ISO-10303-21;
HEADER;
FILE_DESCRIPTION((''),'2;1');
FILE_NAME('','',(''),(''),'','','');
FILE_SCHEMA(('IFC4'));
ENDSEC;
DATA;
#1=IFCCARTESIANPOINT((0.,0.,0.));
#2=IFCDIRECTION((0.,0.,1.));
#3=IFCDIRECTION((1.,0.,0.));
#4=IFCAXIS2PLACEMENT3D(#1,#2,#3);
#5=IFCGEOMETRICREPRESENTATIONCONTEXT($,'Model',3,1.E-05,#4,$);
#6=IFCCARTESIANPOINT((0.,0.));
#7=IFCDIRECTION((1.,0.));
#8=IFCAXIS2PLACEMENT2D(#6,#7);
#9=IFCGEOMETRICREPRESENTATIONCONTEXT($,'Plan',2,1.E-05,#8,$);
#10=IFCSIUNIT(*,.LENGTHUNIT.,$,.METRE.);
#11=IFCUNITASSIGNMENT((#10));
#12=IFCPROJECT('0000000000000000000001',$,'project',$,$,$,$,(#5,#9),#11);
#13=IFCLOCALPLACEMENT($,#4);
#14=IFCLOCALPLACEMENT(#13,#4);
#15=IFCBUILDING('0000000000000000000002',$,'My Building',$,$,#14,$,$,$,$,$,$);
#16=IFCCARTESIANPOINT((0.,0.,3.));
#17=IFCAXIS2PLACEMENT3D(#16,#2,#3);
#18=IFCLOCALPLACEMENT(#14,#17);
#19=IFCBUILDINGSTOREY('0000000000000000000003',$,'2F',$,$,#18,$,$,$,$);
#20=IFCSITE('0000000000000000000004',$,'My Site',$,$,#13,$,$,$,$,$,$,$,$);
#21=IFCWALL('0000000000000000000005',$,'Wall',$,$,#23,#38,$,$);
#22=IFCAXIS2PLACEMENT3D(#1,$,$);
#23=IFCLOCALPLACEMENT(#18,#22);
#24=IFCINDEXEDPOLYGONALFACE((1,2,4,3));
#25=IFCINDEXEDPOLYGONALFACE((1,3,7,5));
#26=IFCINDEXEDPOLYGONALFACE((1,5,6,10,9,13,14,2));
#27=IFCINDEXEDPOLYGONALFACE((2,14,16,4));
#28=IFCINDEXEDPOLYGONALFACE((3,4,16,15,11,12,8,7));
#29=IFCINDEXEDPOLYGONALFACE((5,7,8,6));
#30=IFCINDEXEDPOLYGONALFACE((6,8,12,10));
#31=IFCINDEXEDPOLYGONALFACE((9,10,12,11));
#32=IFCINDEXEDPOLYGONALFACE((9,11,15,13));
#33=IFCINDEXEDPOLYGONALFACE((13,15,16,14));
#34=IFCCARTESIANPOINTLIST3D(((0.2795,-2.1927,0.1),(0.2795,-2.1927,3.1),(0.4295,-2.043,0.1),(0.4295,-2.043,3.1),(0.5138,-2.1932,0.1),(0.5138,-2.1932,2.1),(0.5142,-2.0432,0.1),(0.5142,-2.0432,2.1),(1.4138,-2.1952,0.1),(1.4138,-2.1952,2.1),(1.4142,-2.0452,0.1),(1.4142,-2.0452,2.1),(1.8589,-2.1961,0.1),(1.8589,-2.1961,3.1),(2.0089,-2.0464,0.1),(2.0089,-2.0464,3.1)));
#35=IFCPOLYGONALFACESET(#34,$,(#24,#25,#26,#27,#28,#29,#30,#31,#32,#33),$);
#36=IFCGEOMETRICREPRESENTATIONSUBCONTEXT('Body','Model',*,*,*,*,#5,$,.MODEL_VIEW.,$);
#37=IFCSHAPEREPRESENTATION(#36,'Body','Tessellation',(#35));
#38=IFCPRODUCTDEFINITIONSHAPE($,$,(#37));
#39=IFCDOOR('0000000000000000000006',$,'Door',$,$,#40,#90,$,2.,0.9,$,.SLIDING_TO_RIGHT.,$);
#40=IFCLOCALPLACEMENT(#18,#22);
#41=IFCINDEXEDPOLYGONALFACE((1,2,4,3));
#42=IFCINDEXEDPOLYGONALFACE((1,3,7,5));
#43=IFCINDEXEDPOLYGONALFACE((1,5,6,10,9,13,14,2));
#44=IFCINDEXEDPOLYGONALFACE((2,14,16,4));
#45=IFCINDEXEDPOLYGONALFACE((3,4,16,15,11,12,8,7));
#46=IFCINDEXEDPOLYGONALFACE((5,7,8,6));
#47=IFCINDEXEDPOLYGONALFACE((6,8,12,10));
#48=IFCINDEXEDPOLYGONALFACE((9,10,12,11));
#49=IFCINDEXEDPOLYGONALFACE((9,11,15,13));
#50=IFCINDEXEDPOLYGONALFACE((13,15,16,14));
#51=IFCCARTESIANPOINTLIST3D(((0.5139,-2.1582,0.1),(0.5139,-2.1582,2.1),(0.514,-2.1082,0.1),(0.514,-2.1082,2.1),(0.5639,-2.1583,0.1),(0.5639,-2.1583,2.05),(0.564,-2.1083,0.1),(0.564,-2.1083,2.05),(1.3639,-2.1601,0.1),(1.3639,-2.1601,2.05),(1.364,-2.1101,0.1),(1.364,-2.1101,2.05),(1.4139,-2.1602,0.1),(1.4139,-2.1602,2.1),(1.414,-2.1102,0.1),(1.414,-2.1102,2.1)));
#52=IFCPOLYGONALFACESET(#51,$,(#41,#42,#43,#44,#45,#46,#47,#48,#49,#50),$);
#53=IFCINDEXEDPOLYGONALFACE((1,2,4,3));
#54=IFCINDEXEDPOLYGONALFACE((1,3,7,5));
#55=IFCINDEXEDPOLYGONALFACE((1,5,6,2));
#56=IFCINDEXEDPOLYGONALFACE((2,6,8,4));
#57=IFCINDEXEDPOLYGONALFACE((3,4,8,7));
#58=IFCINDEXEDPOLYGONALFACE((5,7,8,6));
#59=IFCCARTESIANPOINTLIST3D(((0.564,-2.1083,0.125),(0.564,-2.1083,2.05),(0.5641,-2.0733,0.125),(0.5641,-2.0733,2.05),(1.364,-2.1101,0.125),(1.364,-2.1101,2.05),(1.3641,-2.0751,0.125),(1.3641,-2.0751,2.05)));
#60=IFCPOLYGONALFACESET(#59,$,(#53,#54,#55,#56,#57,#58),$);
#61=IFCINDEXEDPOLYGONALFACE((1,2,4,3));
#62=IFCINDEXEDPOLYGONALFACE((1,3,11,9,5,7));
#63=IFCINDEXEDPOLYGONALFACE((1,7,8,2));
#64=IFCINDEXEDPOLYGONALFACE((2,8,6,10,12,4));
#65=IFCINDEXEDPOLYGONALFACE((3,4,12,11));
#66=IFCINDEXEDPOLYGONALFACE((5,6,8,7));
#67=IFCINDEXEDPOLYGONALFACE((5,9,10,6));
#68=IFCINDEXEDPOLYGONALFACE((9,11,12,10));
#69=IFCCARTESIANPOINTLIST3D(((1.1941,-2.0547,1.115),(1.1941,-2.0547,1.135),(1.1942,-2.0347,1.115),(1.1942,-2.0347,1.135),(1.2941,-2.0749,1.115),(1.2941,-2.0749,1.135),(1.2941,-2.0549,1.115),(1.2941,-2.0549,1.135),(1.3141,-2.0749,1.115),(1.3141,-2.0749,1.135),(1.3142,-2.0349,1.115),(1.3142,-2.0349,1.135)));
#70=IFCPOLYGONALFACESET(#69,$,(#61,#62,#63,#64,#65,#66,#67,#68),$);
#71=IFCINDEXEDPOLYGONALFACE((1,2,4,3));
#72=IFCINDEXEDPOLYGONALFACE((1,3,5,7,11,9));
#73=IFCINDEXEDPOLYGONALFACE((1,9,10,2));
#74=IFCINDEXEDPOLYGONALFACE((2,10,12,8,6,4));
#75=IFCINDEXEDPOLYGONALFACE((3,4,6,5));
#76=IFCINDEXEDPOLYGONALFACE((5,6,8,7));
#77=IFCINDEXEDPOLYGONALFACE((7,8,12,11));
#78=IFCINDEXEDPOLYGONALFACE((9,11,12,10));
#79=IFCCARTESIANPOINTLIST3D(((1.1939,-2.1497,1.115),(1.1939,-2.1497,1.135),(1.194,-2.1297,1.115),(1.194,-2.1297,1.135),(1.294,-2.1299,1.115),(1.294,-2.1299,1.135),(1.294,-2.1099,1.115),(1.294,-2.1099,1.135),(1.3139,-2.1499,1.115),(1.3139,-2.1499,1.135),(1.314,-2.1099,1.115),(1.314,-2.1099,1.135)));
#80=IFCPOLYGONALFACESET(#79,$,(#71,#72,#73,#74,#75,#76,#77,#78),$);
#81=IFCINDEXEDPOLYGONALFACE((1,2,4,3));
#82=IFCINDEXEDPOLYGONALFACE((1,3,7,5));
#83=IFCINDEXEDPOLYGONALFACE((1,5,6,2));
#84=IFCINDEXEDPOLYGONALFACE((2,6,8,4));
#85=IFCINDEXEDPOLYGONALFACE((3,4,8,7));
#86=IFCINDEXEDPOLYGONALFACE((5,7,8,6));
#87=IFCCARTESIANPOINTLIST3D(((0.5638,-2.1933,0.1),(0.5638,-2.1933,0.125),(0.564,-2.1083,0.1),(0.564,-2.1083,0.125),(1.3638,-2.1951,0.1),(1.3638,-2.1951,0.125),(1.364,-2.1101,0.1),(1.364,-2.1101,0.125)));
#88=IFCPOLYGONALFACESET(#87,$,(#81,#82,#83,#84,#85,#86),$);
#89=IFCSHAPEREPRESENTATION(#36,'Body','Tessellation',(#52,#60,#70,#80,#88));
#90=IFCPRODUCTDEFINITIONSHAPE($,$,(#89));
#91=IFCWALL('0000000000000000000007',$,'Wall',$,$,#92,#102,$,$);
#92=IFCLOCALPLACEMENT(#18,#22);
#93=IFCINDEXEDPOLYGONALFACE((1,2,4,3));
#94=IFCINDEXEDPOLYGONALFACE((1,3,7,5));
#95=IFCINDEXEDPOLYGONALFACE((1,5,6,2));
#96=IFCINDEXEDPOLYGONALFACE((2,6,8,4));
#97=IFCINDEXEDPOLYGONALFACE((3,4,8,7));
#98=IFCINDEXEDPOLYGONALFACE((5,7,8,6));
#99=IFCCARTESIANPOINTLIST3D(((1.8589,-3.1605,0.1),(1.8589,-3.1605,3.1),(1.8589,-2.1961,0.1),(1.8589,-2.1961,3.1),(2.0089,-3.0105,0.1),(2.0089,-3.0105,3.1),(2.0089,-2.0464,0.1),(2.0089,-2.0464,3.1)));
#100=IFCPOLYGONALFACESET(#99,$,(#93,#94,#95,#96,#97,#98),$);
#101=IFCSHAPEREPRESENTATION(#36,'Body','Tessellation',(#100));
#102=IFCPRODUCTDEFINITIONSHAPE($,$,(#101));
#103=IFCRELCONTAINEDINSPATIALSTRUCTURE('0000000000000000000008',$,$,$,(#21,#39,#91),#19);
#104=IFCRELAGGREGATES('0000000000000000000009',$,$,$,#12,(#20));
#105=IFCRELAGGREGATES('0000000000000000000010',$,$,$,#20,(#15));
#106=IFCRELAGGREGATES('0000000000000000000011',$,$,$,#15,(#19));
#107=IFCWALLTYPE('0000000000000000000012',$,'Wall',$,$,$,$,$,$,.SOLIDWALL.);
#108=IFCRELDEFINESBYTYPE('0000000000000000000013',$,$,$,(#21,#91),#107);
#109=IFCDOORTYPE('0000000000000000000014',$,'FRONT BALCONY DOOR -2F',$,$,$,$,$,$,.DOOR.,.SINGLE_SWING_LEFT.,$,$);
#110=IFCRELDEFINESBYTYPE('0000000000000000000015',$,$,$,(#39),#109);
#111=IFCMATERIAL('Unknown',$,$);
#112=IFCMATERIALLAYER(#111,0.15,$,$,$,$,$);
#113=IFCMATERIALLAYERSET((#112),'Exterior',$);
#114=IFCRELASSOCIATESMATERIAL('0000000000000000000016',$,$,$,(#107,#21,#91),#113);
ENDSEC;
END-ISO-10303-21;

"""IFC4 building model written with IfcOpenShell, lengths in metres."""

from ifc_helpers import new_model, entity, si_unit, frame, origin_with_axes, origin_2d_with_axis, place, context, subcontext, project, spatial, line, indexed_curve, outline, extrude, shape, source, transform, mapped, material, layer, layer_set, layer_usage, type_object, type_shapes, element, fill, save


model = new_model("IFC4")

# Units and contexts
model_context = context("Model", 3, precision=1e-05, world=origin_with_axes())
plan_context = context("Plan", 2, precision=1e-05, world=origin_2d_with_axis())
body_context_1 = subcontext(model_context, "Body", "Model", "MODEL_VIEW")
body_context_2 = subcontext(plan_context, "Body", "Plan", "PLAN_VIEW")
ifc_project = project(units=[si_unit("LENGTHUNIT", "METRE")], contexts=[model_context, plan_context])

# Site, building, storey
site_placement = place(None, origin_with_axes())
site = spatial("IfcSite", under=ifc_project, at=site_placement, Name="My Site")
building_placement = place(site_placement, origin_with_axes())
building = spatial("IfcBuilding", under=site, at=building_placement, Name="My Building")
storey_placement = place(building_placement, frame((0.0, 0.0, 3.0), z_axis=(0.0, 0.0, 1.0), x_axis=(1.0, 0.0, 0.0)))
storey = spatial("IfcBuildingStorey", under=building, at=storey_placement, Name="2F")

# Shared definitions
ifc_material = material(Name="Unknown")

# Shared definitions
ifc_layer_1 = layer(ifc_material, 0.15)
ifc_layer_set_1 = layer_set([ifc_layer_1], Name="Exterior")
wall_type_1 = type_object("IfcWallType", Name="Wall", PredefinedType="SOLIDWALL", material=ifc_layer_set_1)

# Wall, opening, door
ifc_layer_usage_1 = layer_usage(ifc_layer_set_1, "AXIS2", "POSITIVE", 0.0)
wall_1_placement = place(storey_placement, frame((0.2795, -2.1927, 0.1), z_axis=(0.0, 0.0, 1.0), x_axis=(0.999998, -0.002147, 0.0)))
wall_1 = element("IfcWall", 1, at=wall_1_placement, inside=storey, type_object=wall_type_1, material=ifc_layer_usage_1, Name="Wall", context=body_context_1, shape_type="SweptSolid", body=[
    extrude(outline(indexed_curve([(0.0, 0.0), (0.1497, 0.15), (1.729, 0.15), (1.5793, 0.0)], segments=[line(1, 2, 3, 4, 1)])), origin_with_axes(), (0.0, 0.0, 1.0), 3.0),
])
shared_shape_1 = source(origin_with_axes(), body_context_1, "Body", "SweptSolid", [
    extrude(outline(indexed_curve([(0.0, 0.0), (0.9, 0.0), (0.9, 2.0), (0.0, 2.0)], segments=[line(1, 2, 3, 4, 1)])), frame((0.0, -0.6, 0.0), z_axis=(0.0, -1.0, 0.0), x_axis=(1.0, 0.0, 0.0)), (0.0, 0.0, -1.0), 1.2),
])
opening_1_placement = place(wall_1_placement, frame((1.1343, 0.085, 0.0), z_axis=(0.0, 0.0, 1.0), x_axis=(-1.0, 0.0, 0.0)))
opening_1 = element("IfcOpeningElement", 2, at=opening_1_placement, cuts=wall_1, PredefinedType="OPENING", context=body_context_1, shape_type="MappedRepresentation", body=[
    mapped(shared_shape_1, transform((0.0, 0.0, 0.0), x_axis=(1.0, 0.0, 0.0), y_axis=(0.0, 1.0, 0.0), z_axis=(0.0, 0.0, 1.0), scale=1.0)),
])
door_type_1 = type_object("IfcDoorType", Name="FRONT BALCONY DOOR -2F", OperationType="SINGLE_SWING_LEFT", PredefinedType="DOOR")
shared_shape_2 = source(origin_with_axes(), body_context_1, "Body", "SweptSolid", [
    extrude(outline(indexed_curve([(0.0, 0.0), (0.0, 2.0), (0.9, 2.0), (0.9, 0.0), (0.85, 0.0), (0.85, 1.95), (0.05, 1.95), (0.05, 0.0)], segments=[line(1, 2, 3, 4, 5, 6, 7, 8, 1)])), frame((0.0, 0.0, 0.0), z_axis=(0.0, -1.0, 0.0), x_axis=(1.0, 0.0, 0.0)), (0.0, 0.0, -1.0), 0.05),
    extrude(outline(indexed_curve([(0.0, 0.0), (0.8, 0.0), (0.8, 0.035), (0.0, 0.035)], segments=[line(1, 2, 3, 4, 1)])), frame((0.05, -0.035, 0.025), z_axis=(0.0, 0.0, 1.0), x_axis=(1.0, 0.0, 0.0)), (0.0, 0.0, 1.0), 1.925),
    extrude(outline(indexed_curve([(0.0, 0.0), (0.0, -0.04), (0.12, -0.04), (0.12, -0.02), (0.02, -0.02), (0.02, 0.0)], segments=[line(1, 2, 3, 4, 5, 6, 1)])), frame((0.1, -0.035, 1.015), z_axis=(0.0, 0.0, 1.0), x_axis=(1.0, 0.0, 0.0)), (0.0, 0.0, 1.0), 0.02),
    extrude(outline(indexed_curve([(0.0, 0.0), (0.0, 0.04), (0.12, 0.04), (0.12, 0.02), (0.02, 0.02), (0.02, 0.0)], segments=[line(1, 2, 3, 4, 5, 6, 1)])), frame((0.1, 0.0, 1.015), z_axis=(0.0, 0.0, 1.0), x_axis=(1.0, 0.0, 0.0)), (0.0, 0.0, 1.0), 0.02),
    extrude(outline(indexed_curve([(0.0, 0.0), (0.8, 0.0), (0.8, 0.085), (0.0, 0.085)], segments=[line(1, 2, 3, 4, 1)])), frame((0.05, 0.0, 0.0), z_axis=(0.0, 0.0, 1.0), x_axis=(1.0, 0.0, 0.0)), (0.0, 0.0, 1.0), 0.025),
])
shared_shape_3 = source(origin_with_axes(), body_context_2, "Body", "Curve2D", [
    entity("IfcIndexedPolyCurve", entity("IfcCartesianPointList2D", [[0.0, 0.0], [0.05, 0.0], [0.05, 0.05], [0.0, 0.05]]), [entity("IfcLineIndex", [1, 2, 3, 4, 1])]),
    entity("IfcIndexedPolyCurve", entity("IfcCartesianPointList2D", [[0.9, 0.0], [0.85, 0.0], [0.85, 0.05], [0.9, 0.05]]), [entity("IfcLineIndex", [1, 2, 3, 4, 1])]),
    entity("IfcIndexedPolyCurve", entity("IfcCartesianPointList2D", [[1.25, -0.035], [0.45, -0.035], [0.45, 0.0], [1.25, 0.0]]), [entity("IfcLineIndex", [1, 2, 3, 4, 1])]),
])
type_shapes(door_type_1, [shared_shape_2, shared_shape_3])
door_1_placement = place(opening_1_placement, frame((0.0, 0.0, 0.0), z_axis=(0.0, 0.0, 1.0), x_axis=(1.0, 0.0, 0.0)))
door_1 = element("IfcDoor", 3, at=door_1_placement, inside=storey, type_object=door_type_1, Name="Door", OperationType="SLIDING_TO_RIGHT", OverallHeight=2.0, OverallWidth=0.9, shapes=[
    shape(body_context_1, "Body", "MappedRepresentation", [mapped(shared_shape_2, transform((0.0, 0.0, 0.0), x_axis=(1.0, 0.0, 0.0), y_axis=(0.0, 1.0, 0.0), z_axis=(0.0, 0.0, 1.0), scale=1.0))]),
    shape(body_context_2, "Body", "MappedRepresentation", [mapped(shared_shape_3, transform((0.0, 0.0, 0.0), x_axis=(1.0, 0.0, 0.0), y_axis=(0.0, 1.0, 0.0), z_axis=(0.0, 0.0, 1.0), scale=1.0))]),
])
fill(opening_1, door_1)

# Wall
ifc_layer_usage_2 = layer_usage(ifc_layer_set_1, "AXIS2", "POSITIVE", 0.0)
wall_2_placement = place(storey_placement, frame((1.8589, -2.1961, 0.1), z_axis=(0.0, 0.0, 1.0), x_axis=(0.0, -1.0, 0.0)))
element("IfcWall", 4, at=wall_2_placement, inside=storey, type_object=wall_type_1, material=ifc_layer_usage_2, Name="Wall", context=body_context_1, shape_type="SweptSolid", body=[
    extrude(outline(indexed_curve([(0.0, 0.0), (-0.1497, 0.15), (0.8144, 0.15), (0.9644, 0.0)], segments=[line(1, 2, 3, 4, 1)])), origin_with_axes(), (0.0, 0.0, 1.0), 3.0),
])

save(model, "model.ifc")
